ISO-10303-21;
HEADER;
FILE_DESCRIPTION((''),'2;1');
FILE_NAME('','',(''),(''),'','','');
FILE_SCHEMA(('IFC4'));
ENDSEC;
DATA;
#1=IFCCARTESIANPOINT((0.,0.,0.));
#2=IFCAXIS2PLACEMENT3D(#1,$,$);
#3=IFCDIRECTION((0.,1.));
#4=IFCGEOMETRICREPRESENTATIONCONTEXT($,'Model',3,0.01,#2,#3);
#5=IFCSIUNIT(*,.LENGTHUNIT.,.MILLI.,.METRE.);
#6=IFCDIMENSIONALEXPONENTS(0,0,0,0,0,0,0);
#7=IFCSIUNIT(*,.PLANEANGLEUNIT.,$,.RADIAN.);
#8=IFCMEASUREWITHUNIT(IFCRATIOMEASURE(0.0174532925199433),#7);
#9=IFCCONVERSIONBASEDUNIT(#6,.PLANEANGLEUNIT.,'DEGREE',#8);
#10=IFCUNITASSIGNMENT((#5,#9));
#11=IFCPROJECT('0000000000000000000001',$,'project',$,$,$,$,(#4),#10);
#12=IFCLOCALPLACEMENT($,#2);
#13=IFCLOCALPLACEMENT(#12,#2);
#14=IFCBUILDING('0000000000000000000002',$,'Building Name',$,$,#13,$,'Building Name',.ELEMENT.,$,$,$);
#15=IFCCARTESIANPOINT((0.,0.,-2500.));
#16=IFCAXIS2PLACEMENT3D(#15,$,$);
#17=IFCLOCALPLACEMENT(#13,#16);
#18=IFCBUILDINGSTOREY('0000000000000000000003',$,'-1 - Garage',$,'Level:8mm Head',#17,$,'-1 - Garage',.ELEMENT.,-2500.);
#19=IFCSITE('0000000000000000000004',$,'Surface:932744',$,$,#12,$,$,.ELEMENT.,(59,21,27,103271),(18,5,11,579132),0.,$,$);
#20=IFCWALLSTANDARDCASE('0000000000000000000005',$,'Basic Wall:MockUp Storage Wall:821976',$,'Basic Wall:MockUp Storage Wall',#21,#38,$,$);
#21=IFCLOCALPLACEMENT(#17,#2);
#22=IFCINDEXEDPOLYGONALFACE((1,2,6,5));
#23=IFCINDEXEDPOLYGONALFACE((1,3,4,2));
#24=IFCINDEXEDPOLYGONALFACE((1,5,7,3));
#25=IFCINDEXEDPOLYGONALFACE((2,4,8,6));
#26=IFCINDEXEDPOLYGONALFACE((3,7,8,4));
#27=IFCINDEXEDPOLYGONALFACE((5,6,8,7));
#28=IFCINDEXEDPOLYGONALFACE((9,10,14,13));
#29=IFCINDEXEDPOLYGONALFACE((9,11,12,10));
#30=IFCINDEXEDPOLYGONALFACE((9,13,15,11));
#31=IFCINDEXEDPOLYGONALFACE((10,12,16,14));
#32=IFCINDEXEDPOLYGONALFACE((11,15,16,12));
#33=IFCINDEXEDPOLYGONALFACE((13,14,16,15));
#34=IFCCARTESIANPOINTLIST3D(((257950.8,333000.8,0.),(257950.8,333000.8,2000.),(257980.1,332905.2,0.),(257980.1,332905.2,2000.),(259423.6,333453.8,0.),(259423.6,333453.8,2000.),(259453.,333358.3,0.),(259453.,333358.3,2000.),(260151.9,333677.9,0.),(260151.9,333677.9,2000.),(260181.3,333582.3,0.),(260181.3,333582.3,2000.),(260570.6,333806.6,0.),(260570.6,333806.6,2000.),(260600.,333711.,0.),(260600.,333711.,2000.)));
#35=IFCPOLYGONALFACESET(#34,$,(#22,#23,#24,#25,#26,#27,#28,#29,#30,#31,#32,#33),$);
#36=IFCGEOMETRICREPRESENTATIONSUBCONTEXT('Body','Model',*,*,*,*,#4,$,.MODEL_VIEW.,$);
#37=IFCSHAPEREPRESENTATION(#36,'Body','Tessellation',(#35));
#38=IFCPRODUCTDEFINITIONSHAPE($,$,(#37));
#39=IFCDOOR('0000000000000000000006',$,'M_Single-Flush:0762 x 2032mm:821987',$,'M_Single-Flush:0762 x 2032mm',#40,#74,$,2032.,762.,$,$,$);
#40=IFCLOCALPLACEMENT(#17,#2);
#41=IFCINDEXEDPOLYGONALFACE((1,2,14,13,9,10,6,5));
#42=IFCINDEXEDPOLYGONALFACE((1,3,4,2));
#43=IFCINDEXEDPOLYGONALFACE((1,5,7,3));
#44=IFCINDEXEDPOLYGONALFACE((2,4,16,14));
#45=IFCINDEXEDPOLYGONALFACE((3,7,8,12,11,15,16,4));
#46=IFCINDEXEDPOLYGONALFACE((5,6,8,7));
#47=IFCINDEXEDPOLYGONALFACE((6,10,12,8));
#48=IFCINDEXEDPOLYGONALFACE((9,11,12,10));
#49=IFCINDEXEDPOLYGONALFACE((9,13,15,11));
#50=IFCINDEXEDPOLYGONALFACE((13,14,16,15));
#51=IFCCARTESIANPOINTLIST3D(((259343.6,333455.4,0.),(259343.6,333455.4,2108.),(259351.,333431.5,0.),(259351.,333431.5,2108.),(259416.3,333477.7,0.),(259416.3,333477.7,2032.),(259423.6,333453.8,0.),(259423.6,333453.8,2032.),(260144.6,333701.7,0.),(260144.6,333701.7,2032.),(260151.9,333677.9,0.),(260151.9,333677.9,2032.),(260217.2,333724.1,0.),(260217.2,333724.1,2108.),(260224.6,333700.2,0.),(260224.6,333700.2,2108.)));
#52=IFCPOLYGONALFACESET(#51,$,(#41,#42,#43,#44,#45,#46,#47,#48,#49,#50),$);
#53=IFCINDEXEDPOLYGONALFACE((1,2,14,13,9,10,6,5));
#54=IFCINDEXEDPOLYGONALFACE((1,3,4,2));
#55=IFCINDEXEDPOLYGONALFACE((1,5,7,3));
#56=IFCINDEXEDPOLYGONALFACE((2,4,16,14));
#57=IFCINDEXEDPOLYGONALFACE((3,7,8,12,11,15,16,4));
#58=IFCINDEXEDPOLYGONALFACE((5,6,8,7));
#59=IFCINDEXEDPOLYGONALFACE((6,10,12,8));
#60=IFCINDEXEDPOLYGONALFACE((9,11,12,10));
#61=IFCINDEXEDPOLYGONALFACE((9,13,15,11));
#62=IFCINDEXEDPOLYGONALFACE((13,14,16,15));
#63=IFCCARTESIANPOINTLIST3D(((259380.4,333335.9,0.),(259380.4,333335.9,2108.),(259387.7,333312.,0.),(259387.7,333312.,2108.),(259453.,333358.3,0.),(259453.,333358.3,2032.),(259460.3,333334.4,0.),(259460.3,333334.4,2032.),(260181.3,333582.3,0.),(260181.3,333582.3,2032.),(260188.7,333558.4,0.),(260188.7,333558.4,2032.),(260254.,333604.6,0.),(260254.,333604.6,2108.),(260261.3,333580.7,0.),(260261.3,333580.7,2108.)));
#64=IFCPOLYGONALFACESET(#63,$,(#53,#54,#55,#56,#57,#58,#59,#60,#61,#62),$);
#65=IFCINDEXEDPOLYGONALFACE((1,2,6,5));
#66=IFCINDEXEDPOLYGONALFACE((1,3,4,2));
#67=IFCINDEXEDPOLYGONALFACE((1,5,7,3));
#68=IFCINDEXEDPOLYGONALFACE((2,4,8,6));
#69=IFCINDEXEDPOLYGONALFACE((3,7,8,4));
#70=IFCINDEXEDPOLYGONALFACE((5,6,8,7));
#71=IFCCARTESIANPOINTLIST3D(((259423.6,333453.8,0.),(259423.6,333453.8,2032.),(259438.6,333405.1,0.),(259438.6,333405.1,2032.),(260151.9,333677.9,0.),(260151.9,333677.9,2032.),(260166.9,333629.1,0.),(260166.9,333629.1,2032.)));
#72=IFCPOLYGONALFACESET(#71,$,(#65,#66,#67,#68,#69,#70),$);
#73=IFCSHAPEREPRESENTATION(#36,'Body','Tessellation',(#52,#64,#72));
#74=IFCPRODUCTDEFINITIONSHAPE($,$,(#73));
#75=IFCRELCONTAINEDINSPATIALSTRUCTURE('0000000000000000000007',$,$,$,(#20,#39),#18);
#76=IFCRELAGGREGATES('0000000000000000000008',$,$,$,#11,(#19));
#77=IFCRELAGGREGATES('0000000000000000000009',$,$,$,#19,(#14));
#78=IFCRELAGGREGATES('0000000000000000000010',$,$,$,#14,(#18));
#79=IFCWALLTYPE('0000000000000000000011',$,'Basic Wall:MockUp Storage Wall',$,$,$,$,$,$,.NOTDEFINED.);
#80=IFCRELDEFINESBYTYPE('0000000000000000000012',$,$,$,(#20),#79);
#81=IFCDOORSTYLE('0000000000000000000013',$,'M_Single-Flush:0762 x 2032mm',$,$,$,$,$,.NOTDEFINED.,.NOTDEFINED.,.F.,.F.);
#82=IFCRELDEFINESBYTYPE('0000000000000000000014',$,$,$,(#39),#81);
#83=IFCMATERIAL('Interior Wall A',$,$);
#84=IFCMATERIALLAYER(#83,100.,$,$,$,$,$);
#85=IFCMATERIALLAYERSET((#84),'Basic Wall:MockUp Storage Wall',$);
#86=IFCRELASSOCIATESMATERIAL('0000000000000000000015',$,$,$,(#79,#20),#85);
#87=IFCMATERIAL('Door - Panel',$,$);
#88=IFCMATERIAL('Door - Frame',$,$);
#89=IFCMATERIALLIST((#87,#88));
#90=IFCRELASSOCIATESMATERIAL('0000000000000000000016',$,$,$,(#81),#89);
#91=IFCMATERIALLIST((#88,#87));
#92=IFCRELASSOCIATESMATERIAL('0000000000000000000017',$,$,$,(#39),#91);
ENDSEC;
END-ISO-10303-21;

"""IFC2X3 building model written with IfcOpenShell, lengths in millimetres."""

from ifc_helpers import new_model, entity, si_unit, converted_unit, direction, frame, frame_2d, origin, origin_2d_with_axis, place, context, subcontext, project, spatial, polyline, rectangle, outline, extrude, source, transform, mapped, material, material_list, layer, layer_set, layer_usage, type_object, type_shapes, element, fill, save


model = new_model("IFC2X3")

# Units and contexts
model_context = context("Model", 3, precision=0.01, world=origin(), true_north=direction((0.0, 1.0)))
body_context = subcontext(model_context, "Body", "Model", "MODEL_VIEW")
ifc_project = project(units=[si_unit("LENGTHUNIT", "METRE", prefix="MILLI"), converted_unit("PLANEANGLEUNIT", "DEGREE", entity("IfcRatioMeasure", 0.0174532925199433), si_unit("PLANEANGLEUNIT", "RADIAN"), dimensions=[0, 0, 0, 0, 0, 0, 0])], contexts=[model_context])

# Site, building, storey
site_placement = place(None, origin())
site = spatial("IfcSite", under=ifc_project, at=site_placement, Name="Surface:932744", CompositionType="ELEMENT", RefLatitude=(59, 21, 27, 103271), RefLongitude=(18, 5, 11, 579132), RefElevation=0.0)
building_placement = place(site_placement, origin())
building = spatial("IfcBuilding", under=site, at=building_placement, Name="Building Name", LongName="Building Name", CompositionType="ELEMENT")
storey_placement = place(building_placement, frame((0.0, 0.0, -2500.0)))
storey = spatial("IfcBuildingStorey", under=building, at=storey_placement, Name="-1 - Garage", ObjectType="Level:8mm Head", LongName="-1 - Garage", CompositionType="ELEMENT", Elevation=-2500.0)

# Shared definitions
ifc_material_1 = material(Name="Door - Frame")
ifc_material_2 = material(Name="Door - Panel")

# Shared definitions
ifc_material_3 = material(Name="Interior Wall A")
ifc_layer_1 = layer(ifc_material_3, 100.0)
ifc_layer_set_1 = layer_set([ifc_layer_1], Name="Basic Wall:MockUp Storage Wall")
wall_type_1 = type_object("IfcWallType", Name="Basic Wall:MockUp Storage Wall", PredefinedType="NOTDEFINED", material=ifc_layer_set_1)
ifc_material_list_1 = material_list([ifc_material_2, ifc_material_1])
door_style_1 = type_object("IfcDoorStyle", Name="M_Single-Flush:0762 x 2032mm", ConstructionType="NOTDEFINED", OperationType="NOTDEFINED", ParameterTakesPrecedence=False, Sizeable=False, material=ifc_material_list_1)
shared_shape_1 = source(origin(), body_context, "Body", "SweptSolid", [
    extrude(outline(polyline([(-457.0, -1073.0), (457.0, -1073.0), (457.0, 1035.0), (381.0, 1035.0), (381.0, -997.0), (-381.0, -997.0), (-381.0, 1035.0), (-457.0, 1035.0), (-457.0, -1073.0)])), frame((381.0, 100.0, 1035.0), z_axis=(0.0, 1.0, 0.0), x_axis=(1.0, 0.0, 0.0)), (0.0, 0.0, 1.0), 25.0),
    extrude(outline(polyline([(-1073.0, -457.0), (1035.0, -457.0), (1035.0, -381.0), (-997.0, -381.0), (-997.0, 381.0), (1035.0, 381.0), (1035.0, 457.0), (-1073.0, 457.0), (-1073.0, -457.0)])), frame((381.0, -25.0, 1035.0), z_axis=(0.0, 1.0, 0.0), x_axis=(0.0, 0.0, -1.0)), (0.0, 0.0, 1.0), 25.0),
    extrude(rectangle(XDim=51.0, YDim=762.0, at=origin_2d_with_axis()), frame((381.0, 74.5, 0.0), z_axis=(0.0, 0.0, 1.0), x_axis=(0.0, 1.0, 0.0)), (0.0, 0.0, 1.0), 2032.0),
])
type_shapes(door_style_1, [shared_shape_1])

# Wall, opening, door
ifc_layer_usage_1 = layer_usage(ifc_layer_set_1, "AXIS2", "NEGATIVE", 50.0)
wall_1_placement = place(storey_placement, frame((257965.4, 332953.0, 0.0), z_axis=(0.0, 0.0, 1.0), x_axis=(0.955811, 0.29398, 0.0)))
wall_1 = element("IfcWallStandardCase", 1, at=wall_1_placement, inside=storey, type_object=wall_type_1, material=ifc_layer_usage_1, Name="Basic Wall:MockUp Storage Wall:821976", ObjectType="Basic Wall:MockUp Storage Wall", context=body_context, shape_type="SweptSolid", body=[
    extrude(outline(polyline([(0.0, -50.0), (2741.0, -50.0), (2741.0, 50.0), (0.1, 50.0), (0.0, -50.0)])), origin(), (0.0, 0.0, 1.0), 2000.0),
])
opening_1_placement = place(wall_1_placement, frame((1541.0, -50.0, 0.0)))
opening_1 = element("IfcOpeningElement", 2, at=opening_1_placement, cuts=wall_1, ObjectType="Opening", context=body_context, shape_type="SweptSolid", body=[
    extrude(rectangle(XDim=762.0, YDim=2032.0, at=frame_2d((1016.0, 381.0), x_axis=(0.0, 1.0))), frame((0.0, 0.0, 0.0), z_axis=(0.0, 1.0, 0.0), x_axis=(0.0, 0.0, 1.0)), (0.0, 0.0, 1.0), 100.0),
])
ifc_material_list_2 = material_list([ifc_material_1, ifc_material_2])
door_1_placement = place(opening_1_placement, frame((0.0, 0.0, 0.0)))
door_1 = element("IfcDoor", 3, at=door_1_placement, inside=storey, type_object=door_style_1, material=ifc_material_list_2, Name="M_Single-Flush:0762 x 2032mm:821987", ObjectType="M_Single-Flush:0762 x 2032mm", OverallHeight=2032.0, OverallWidth=762.0, context=body_context, shape_type="MappedRepresentation", body=[
    mapped(shared_shape_1, transform((0.0, 0.0, 0.0), scale=1.0)),
])
fill(opening_1, door_1)

save(model, "model.ifc")
